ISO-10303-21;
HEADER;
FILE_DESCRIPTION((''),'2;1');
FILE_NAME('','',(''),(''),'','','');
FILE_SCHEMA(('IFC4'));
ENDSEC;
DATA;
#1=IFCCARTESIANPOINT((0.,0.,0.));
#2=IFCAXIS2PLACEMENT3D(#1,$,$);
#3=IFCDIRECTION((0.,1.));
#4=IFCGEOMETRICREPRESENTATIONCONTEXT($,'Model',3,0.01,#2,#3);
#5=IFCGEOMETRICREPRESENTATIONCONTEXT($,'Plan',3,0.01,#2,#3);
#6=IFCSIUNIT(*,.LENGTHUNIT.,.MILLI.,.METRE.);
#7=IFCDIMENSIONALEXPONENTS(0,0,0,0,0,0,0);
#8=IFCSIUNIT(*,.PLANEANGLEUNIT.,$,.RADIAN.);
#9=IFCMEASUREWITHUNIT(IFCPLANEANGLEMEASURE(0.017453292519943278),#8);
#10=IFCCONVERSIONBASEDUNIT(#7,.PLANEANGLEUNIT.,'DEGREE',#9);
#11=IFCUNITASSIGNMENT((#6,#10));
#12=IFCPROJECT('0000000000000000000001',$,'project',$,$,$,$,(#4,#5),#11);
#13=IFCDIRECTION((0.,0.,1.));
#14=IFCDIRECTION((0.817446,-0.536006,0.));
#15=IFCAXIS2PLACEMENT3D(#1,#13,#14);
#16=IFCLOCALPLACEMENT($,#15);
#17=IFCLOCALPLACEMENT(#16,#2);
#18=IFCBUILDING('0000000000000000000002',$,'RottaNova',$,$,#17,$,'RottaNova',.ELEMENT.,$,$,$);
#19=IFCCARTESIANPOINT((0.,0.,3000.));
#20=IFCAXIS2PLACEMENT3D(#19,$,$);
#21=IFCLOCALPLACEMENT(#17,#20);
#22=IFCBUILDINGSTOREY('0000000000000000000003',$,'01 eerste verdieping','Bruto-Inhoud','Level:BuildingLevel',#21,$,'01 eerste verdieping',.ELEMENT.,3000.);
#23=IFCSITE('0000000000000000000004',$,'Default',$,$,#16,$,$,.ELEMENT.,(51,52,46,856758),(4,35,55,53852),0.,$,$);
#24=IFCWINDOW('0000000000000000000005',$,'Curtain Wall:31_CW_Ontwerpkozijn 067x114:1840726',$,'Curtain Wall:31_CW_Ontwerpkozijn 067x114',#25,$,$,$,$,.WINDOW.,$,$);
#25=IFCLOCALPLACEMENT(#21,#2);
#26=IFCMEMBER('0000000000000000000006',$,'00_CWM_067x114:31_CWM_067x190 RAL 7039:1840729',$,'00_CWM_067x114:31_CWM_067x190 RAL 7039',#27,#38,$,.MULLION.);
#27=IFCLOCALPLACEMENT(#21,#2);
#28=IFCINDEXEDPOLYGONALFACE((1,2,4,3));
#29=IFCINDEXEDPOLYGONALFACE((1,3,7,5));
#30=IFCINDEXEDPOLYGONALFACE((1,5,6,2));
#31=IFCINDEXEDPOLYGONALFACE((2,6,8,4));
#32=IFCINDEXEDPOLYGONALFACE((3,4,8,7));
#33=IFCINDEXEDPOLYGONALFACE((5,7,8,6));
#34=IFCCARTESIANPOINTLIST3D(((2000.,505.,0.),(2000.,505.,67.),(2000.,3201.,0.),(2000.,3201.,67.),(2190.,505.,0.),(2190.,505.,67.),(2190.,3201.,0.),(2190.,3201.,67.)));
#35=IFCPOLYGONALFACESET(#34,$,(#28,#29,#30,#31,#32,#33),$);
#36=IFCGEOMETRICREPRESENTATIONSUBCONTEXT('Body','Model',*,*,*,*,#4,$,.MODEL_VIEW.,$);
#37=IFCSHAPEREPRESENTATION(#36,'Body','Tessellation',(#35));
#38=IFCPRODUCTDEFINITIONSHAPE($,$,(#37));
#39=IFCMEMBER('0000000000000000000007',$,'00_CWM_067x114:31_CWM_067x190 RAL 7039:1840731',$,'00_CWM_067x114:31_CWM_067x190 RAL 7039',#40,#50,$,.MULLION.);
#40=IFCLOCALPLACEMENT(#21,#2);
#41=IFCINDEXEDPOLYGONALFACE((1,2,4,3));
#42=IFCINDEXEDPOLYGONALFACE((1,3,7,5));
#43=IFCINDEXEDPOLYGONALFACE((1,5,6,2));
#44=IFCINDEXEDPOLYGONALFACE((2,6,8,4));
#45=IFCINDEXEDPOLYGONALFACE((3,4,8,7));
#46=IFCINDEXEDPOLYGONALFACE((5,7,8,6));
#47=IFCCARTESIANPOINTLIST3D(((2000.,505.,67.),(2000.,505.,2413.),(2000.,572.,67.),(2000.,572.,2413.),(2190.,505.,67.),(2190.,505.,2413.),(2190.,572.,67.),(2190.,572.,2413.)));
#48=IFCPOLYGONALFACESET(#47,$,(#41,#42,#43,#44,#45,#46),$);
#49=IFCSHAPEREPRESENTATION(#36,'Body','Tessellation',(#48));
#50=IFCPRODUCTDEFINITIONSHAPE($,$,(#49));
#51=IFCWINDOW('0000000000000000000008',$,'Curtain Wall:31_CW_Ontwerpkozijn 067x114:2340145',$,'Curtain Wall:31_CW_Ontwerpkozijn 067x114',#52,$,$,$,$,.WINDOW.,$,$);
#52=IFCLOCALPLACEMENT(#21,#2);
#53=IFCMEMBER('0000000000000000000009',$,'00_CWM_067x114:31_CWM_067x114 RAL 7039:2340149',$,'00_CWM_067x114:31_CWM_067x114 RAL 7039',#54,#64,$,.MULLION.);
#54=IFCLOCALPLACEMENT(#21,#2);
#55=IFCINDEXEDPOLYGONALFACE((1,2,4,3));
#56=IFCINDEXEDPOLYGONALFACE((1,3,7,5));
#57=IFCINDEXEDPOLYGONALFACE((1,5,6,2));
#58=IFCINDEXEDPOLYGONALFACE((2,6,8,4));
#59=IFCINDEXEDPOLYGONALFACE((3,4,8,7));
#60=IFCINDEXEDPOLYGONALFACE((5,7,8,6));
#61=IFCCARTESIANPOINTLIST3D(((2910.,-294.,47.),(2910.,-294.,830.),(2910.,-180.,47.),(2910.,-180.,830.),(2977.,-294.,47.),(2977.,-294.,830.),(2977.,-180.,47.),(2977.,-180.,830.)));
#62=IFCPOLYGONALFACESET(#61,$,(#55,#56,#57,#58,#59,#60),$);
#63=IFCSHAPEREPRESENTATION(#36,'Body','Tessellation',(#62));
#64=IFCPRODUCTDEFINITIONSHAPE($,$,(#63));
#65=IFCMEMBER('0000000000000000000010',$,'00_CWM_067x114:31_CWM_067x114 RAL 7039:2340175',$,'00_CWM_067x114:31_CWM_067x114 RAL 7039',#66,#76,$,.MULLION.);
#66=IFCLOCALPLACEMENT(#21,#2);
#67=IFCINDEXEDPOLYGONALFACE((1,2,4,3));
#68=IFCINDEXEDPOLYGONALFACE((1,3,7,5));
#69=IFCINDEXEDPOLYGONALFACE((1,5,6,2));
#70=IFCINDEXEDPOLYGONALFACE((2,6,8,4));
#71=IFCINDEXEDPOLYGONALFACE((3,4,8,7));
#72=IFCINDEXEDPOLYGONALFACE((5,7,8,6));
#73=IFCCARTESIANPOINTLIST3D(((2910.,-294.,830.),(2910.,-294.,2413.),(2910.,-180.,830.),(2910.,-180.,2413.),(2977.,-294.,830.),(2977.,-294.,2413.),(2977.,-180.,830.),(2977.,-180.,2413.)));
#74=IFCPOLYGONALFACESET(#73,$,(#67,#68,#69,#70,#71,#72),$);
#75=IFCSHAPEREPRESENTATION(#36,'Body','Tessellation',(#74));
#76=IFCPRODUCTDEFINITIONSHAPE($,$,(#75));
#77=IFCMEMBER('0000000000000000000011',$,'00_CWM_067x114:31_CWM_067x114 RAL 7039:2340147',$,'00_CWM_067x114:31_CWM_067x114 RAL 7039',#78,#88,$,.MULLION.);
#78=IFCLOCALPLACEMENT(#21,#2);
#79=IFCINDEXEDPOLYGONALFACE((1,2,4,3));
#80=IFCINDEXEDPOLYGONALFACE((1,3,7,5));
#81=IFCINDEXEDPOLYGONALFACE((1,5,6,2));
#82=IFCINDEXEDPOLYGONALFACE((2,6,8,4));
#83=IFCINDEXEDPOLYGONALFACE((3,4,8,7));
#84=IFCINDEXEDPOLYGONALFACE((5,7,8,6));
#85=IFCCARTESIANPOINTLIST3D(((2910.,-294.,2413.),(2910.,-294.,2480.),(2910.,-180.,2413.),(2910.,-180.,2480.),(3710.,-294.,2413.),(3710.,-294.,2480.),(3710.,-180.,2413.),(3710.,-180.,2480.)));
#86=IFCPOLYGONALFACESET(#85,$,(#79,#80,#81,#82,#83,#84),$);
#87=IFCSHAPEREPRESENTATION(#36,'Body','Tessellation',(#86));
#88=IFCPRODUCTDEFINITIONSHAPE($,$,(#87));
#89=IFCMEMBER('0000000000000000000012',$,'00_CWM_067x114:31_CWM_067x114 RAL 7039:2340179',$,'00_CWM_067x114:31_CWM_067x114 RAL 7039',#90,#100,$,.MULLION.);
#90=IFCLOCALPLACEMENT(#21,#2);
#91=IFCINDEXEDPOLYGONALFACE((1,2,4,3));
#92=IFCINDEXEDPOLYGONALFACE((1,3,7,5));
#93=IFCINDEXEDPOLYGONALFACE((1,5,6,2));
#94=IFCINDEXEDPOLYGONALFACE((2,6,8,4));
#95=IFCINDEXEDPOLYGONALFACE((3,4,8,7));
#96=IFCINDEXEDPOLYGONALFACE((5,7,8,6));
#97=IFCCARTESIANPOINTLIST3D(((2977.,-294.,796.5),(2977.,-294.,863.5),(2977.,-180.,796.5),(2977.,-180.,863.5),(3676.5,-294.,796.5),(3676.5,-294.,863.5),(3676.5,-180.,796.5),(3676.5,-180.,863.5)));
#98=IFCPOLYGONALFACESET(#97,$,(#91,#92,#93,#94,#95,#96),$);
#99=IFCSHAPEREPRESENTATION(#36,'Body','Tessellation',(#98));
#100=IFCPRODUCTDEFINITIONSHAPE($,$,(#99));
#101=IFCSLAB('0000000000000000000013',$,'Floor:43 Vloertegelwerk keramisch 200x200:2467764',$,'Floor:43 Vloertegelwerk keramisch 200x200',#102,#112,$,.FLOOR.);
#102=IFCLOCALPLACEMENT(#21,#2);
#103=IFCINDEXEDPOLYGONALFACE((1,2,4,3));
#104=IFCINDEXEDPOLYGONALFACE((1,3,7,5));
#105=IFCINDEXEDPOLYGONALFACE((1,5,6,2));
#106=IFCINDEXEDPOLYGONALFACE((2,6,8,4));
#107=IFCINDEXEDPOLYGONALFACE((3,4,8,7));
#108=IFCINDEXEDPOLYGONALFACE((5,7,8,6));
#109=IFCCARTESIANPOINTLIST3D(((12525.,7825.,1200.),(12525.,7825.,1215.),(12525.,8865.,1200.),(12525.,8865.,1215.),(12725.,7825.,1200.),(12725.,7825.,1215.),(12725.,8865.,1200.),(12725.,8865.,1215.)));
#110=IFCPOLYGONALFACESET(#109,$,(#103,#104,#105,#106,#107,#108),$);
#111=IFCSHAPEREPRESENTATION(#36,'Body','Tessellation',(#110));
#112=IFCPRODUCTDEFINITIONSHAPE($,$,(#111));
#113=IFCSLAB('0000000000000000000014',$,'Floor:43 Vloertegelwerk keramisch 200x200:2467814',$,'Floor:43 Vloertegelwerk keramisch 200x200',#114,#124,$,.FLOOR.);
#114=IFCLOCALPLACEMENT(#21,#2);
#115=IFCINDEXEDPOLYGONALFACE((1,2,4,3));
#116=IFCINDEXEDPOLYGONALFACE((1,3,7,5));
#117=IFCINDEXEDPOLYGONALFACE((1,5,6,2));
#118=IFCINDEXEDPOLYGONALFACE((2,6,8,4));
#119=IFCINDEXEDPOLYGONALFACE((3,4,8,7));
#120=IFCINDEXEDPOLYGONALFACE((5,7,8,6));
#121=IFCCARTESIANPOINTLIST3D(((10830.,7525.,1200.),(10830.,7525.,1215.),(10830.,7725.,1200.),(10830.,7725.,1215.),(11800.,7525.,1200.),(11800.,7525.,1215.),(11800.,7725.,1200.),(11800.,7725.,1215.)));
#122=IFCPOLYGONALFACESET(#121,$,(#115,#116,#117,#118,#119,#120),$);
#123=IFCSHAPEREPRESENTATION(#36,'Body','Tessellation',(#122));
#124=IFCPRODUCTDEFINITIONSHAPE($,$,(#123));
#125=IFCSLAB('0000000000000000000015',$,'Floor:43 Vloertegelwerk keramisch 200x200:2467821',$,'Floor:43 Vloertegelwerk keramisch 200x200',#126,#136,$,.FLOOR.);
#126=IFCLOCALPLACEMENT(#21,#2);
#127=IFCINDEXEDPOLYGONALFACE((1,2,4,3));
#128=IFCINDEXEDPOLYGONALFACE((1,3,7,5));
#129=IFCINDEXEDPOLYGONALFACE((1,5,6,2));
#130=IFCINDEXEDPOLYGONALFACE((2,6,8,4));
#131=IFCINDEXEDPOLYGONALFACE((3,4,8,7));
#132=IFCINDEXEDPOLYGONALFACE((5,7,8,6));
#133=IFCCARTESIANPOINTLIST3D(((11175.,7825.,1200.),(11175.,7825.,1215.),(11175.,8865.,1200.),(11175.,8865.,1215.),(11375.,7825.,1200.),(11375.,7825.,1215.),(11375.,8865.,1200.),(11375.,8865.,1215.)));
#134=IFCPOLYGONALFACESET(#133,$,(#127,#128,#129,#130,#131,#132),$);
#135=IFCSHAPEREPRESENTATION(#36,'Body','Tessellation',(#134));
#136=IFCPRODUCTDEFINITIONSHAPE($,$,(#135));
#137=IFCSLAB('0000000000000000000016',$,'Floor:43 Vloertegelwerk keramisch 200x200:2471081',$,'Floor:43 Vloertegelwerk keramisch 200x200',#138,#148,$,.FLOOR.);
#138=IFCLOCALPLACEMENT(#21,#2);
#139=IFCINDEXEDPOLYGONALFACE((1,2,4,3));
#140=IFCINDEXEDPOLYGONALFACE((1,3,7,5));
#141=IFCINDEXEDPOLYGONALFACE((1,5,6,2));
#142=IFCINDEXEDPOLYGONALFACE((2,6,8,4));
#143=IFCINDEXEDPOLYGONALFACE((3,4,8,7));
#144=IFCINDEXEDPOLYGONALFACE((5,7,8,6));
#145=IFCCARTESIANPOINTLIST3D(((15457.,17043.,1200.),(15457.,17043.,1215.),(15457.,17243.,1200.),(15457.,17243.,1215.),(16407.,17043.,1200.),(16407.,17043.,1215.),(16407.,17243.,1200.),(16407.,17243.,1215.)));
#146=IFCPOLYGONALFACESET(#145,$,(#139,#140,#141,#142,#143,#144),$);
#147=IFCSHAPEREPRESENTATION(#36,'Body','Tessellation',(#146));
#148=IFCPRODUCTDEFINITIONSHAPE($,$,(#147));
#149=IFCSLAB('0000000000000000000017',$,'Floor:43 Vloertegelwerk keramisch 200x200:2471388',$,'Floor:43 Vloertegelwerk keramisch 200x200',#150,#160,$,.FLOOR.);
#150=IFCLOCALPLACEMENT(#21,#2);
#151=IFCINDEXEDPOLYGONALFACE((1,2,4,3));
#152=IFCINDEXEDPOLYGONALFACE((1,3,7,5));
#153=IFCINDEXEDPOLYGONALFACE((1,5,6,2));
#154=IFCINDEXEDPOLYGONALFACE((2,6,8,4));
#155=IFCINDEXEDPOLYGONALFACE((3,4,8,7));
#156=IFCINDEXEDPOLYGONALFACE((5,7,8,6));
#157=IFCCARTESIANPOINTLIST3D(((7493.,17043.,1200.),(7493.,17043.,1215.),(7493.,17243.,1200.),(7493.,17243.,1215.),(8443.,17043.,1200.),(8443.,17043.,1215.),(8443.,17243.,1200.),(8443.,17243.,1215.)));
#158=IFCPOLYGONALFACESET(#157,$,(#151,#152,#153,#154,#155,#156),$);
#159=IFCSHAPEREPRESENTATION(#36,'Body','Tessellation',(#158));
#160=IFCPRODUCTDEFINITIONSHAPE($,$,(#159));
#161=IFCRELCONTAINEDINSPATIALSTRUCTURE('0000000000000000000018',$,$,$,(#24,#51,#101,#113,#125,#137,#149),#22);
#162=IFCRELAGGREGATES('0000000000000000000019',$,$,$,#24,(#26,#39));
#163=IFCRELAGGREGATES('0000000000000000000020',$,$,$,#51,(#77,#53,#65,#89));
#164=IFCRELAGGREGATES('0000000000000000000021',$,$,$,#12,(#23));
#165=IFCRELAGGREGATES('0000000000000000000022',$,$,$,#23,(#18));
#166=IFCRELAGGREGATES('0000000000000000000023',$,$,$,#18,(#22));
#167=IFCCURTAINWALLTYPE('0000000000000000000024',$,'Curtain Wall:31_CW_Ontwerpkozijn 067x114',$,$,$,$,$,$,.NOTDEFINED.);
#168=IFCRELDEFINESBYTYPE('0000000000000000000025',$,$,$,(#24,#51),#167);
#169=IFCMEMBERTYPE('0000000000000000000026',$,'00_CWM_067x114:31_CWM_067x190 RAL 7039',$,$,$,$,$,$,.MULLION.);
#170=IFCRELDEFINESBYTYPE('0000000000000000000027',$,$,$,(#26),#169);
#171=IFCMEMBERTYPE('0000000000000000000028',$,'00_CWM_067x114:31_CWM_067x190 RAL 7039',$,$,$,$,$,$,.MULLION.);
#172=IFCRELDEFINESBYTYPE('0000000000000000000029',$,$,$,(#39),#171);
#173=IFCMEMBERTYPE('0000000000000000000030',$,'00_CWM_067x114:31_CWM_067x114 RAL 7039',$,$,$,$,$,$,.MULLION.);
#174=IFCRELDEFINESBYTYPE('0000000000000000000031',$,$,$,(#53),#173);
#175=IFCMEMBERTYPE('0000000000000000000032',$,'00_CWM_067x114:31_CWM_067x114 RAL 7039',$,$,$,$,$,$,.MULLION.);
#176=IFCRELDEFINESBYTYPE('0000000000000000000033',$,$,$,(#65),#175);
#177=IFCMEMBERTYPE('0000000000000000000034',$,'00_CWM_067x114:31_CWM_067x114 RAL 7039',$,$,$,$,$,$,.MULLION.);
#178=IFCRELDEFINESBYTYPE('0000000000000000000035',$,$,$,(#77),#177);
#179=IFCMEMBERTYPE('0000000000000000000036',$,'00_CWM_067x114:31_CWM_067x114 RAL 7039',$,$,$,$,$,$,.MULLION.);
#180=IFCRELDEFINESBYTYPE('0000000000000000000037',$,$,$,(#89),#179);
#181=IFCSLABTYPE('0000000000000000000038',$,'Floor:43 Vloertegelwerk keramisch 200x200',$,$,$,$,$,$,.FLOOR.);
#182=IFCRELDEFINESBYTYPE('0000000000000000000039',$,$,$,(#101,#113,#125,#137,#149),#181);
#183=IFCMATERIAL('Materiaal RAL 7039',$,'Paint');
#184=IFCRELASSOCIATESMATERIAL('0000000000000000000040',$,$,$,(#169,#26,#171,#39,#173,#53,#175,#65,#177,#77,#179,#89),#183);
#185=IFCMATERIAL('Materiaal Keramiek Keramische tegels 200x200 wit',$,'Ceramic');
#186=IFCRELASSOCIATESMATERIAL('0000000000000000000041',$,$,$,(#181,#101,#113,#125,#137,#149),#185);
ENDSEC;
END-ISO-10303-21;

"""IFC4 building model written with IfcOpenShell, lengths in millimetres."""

from ifc_helpers import new_model, entity, si_unit, converted_unit, direction, frame, origin, place, context, subcontext, project, spatial, indexed_curve, outline, extrude, source, transform, mapped, material, type_object, type_shapes, element, aggregate, save


model = new_model("IFC4")

# Units and contexts
model_context = context("Model", 3, precision=0.01, world=origin(), true_north=direction((0.0, 1.0)))
plan_context = context("Plan", 3, precision=0.01, world=origin(), true_north=direction((0.0, 1.0)))
body_context = subcontext(model_context, "Body", "Model", "MODEL_VIEW")
ifc_project = project(units=[si_unit("LENGTHUNIT", "METRE", prefix="MILLI"), converted_unit("PLANEANGLEUNIT", "DEGREE", entity("IfcPlaneAngleMeasure", 0.017453292519943278), si_unit("PLANEANGLEUNIT", "RADIAN"), dimensions=[0, 0, 0, 0, 0, 0, 0])], contexts=[model_context, plan_context])

# Site, building, storey
site_placement = place(None, frame((0.0, 0.0, 0.0), z_axis=(0.0, 0.0, 1.0), x_axis=(0.817446, -0.536006, 0.0)))
site = spatial("IfcSite", under=ifc_project, at=site_placement, Name="Default", CompositionType="ELEMENT", RefLatitude=(51, 52, 46, 856758), RefLongitude=(4, 35, 55, 53852), RefElevation=0.0)
building_placement = place(site_placement, origin())
building = spatial("IfcBuilding", under=site, at=building_placement, Name="RottaNova", LongName="RottaNova", CompositionType="ELEMENT")
storey_placement = place(building_placement, frame((0.0, 0.0, 3000.0)))
storey = spatial("IfcBuildingStorey", under=building, at=storey_placement, Name="01 eerste verdieping", Description="Bruto-Inhoud", ObjectType="Level:BuildingLevel", LongName="01 eerste verdieping", CompositionType="ELEMENT", Elevation=3000.0)

# Windows, members
curtain_wall_type = type_object("IfcCurtainWallType", Name="Curtain Wall:31_CW_Ontwerpkozijn 067x114", PredefinedType="NOTDEFINED")
window_1_placement = place(storey_placement, frame((0.0, 0.0, -3000.0)))
window_1 = element("IfcWindow", 1, at=window_1_placement, inside=storey, type_object=curtain_wall_type, Name="Curtain Wall:31_CW_Ontwerpkozijn 067x114:1840726", ObjectType="Curtain Wall:31_CW_Ontwerpkozijn 067x114", PredefinedType="WINDOW")
ifc_material_1 = material(Name="Materiaal RAL 7039", Category="Paint")
member_type_1 = type_object("IfcMemberType", Name="00_CWM_067x114:31_CWM_067x190 RAL 7039", PredefinedType="MULLION", material=ifc_material_1)
shared_shape_1 = source(origin(), body_context, "Body", "SweptSolid", [
    extrude(outline(indexed_curve([(-33.5, -95.0), (33.5, -95.0), (33.5, 95.0), (-33.5, 95.0), (-33.5, -95.0)], self_intersect=False)), frame((-33.5, -95.0, -2696.0), z_axis=(0.0, 0.0, 1.0), x_axis=(-1.0, 0.0, 0.0)), (0.0, 0.0, 1.0), 2696.0),
])
type_shapes(member_type_1, [shared_shape_1])
member_1_placement = place(window_1_placement, frame((2190.0, 505.0, 3000.0), z_axis=(0.0, -1.0, 0.0), x_axis=(0.0, 0.0, -1.0)))
member_1 = element("IfcMember", 2, at=member_1_placement, type_object=member_type_1, material=ifc_material_1, Name="00_CWM_067x114:31_CWM_067x190 RAL 7039:1840729", ObjectType="00_CWM_067x114:31_CWM_067x190 RAL 7039", PredefinedType="MULLION", context=body_context, shape_type="MappedRepresentation", body=[
    mapped(shared_shape_1, transform((0.0, 0.0, 0.0), scale=1.0)),
])
member_type_2 = type_object("IfcMemberType", Name="00_CWM_067x114:31_CWM_067x190 RAL 7039", PredefinedType="MULLION", material=ifc_material_1)
shared_shape_2 = source(origin(), body_context, "Body", "SweptSolid", [
    extrude(outline(indexed_curve([(-33.5, -95.0), (33.5, -95.0), (33.5, 95.0), (-33.5, 95.0), (-33.5, -95.0)], self_intersect=False)), frame((-33.5, -95.0, -2346.0), z_axis=(0.0, 0.0, 1.0), x_axis=(-1.0, 0.0, 0.0)), (0.0, 0.0, 1.0), 2346.0),
])
type_shapes(member_type_2, [shared_shape_2])
member_2_placement = place(window_1_placement, frame((2190.0, 505.0, 5413.0), z_axis=(0.0, 0.0, 1.0), x_axis=(0.0, -1.0, 0.0)))
member_2 = element("IfcMember", 3, at=member_2_placement, type_object=member_type_2, material=ifc_material_1, Name="00_CWM_067x114:31_CWM_067x190 RAL 7039:1840731", ObjectType="00_CWM_067x114:31_CWM_067x190 RAL 7039", PredefinedType="MULLION", context=body_context, shape_type="MappedRepresentation", body=[
    mapped(shared_shape_2, transform((0.0, 0.0, 0.0), scale=1.0)),
])
aggregate(window_1, [member_1, member_2])
window_2_placement = place(storey_placement, frame((0.0, 0.0, -3000.0)))
window_2 = element("IfcWindow", 4, at=window_2_placement, inside=storey, type_object=curtain_wall_type, Name="Curtain Wall:31_CW_Ontwerpkozijn 067x114:2340145", ObjectType="Curtain Wall:31_CW_Ontwerpkozijn 067x114", PredefinedType="WINDOW")
member_type_3 = type_object("IfcMemberType", Name="00_CWM_067x114:31_CWM_067x114 RAL 7039", PredefinedType="MULLION", material=ifc_material_1)
shared_shape_3 = source(origin(), body_context, "Body", "SweptSolid", [
    extrude(outline(indexed_curve([(-33.5, -57.0), (33.5, -57.0), (33.5, 57.0), (-33.5, 57.0), (-33.5, -57.0)], self_intersect=False)), frame((-33.5, -57.0, -783.0), z_axis=(0.0, 0.0, 1.0), x_axis=(-1.0, 0.0, 0.0)), (0.0, 0.0, 1.0), 783.0),
])
type_shapes(member_type_3, [shared_shape_3])
member_3_placement = place(window_2_placement, frame((2910.0, -180.0, 3047.0), z_axis=(0.0, 0.0, -1.0), x_axis=(-1.0, 0.0, 0.0)))
member_3 = element("IfcMember", 5, at=member_3_placement, type_object=member_type_3, material=ifc_material_1, Name="00_CWM_067x114:31_CWM_067x114 RAL 7039:2340149", ObjectType="00_CWM_067x114:31_CWM_067x114 RAL 7039", PredefinedType="MULLION", context=body_context, shape_type="MappedRepresentation", body=[
    mapped(shared_shape_3, transform((0.0, 0.0, 0.0), scale=1.0)),
])
member_type_4 = type_object("IfcMemberType", Name="00_CWM_067x114:31_CWM_067x114 RAL 7039", PredefinedType="MULLION", material=ifc_material_1)
shared_shape_4 = source(origin(), body_context, "Body", "SweptSolid", [
    extrude(outline(indexed_curve([(-33.5, -57.0), (33.5, -57.0), (33.5, 57.0), (-33.5, 57.0), (-33.5, -57.0)], self_intersect=False)), frame((-33.5, -57.0, -1583.0), z_axis=(0.0, 0.0, 1.0), x_axis=(-1.0, 0.0, 0.0)), (0.0, 0.0, 1.0), 1583.0),
])
type_shapes(member_type_4, [shared_shape_4])
member_4_placement = place(window_2_placement, frame((2910.0, -180.0, 3830.0), z_axis=(0.0, 0.0, -1.0), x_axis=(-1.0, 0.0, 0.0)))
member_4 = element("IfcMember", 6, at=member_4_placement, type_object=member_type_4, material=ifc_material_1, Name="00_CWM_067x114:31_CWM_067x114 RAL 7039:2340175", ObjectType="00_CWM_067x114:31_CWM_067x114 RAL 7039", PredefinedType="MULLION", context=body_context, shape_type="MappedRepresentation", body=[
    mapped(shared_shape_4, transform((0.0, 0.0, 0.0), scale=1.0)),
])
member_type_5 = type_object("IfcMemberType", Name="00_CWM_067x114:31_CWM_067x114 RAL 7039", PredefinedType="MULLION", material=ifc_material_1)
shared_shape_5 = source(origin(), body_context, "Body", "SweptSolid", [
    extrude(outline(indexed_curve([(-33.5, -57.0), (33.5, -57.0), (33.5, 57.0), (-33.5, 57.0), (-33.5, -57.0)], self_intersect=False)), frame((-33.5, -57.0, -800.0), z_axis=(0.0, 0.0, 1.0), x_axis=(-1.0, 0.0, 0.0)), (0.0, 0.0, 1.0), 800.0),
])
type_shapes(member_type_5, [shared_shape_5])
member_5_placement = place(window_2_placement, frame((2910.0, -180.0, 5480.0), z_axis=(-1.0, 0.0, 0.0), x_axis=(0.0, 0.0, 1.0)))
member_5 = element("IfcMember", 7, at=member_5_placement, type_object=member_type_5, material=ifc_material_1, Name="00_CWM_067x114:31_CWM_067x114 RAL 7039:2340147", ObjectType="00_CWM_067x114:31_CWM_067x114 RAL 7039", PredefinedType="MULLION", context=body_context, shape_type="MappedRepresentation", body=[
    mapped(shared_shape_5, transform((0.0, 0.0, 0.0), scale=1.0)),
])
member_type_6 = type_object("IfcMemberType", Name="00_CWM_067x114:31_CWM_067x114 RAL 7039", PredefinedType="MULLION", material=ifc_material_1)
shared_shape_6 = source(origin(), body_context, "Body", "SweptSolid", [
    extrude(outline(indexed_curve([(-33.5, -57.0), (33.5, -57.0), (33.5, 57.0), (-33.5, 57.0), (-33.5, -57.0)], self_intersect=False)), frame((0.0, -57.0, -699.5), z_axis=(0.0, 0.0, 1.0), x_axis=(-1.0, 0.0, 0.0)), (0.0, 0.0, 1.0), 699.5),
])
type_shapes(member_type_6, [shared_shape_6])
member_6_placement = place(window_2_placement, frame((2977.0, -180.0, 3830.0), z_axis=(-1.0, 0.0, 0.0), x_axis=(0.0, 0.0, 1.0)))
member_6 = element("IfcMember", 8, at=member_6_placement, type_object=member_type_6, material=ifc_material_1, Name="00_CWM_067x114:31_CWM_067x114 RAL 7039:2340179", ObjectType="00_CWM_067x114:31_CWM_067x114 RAL 7039", PredefinedType="MULLION", context=body_context, shape_type="MappedRepresentation", body=[
    mapped(shared_shape_6, transform((0.0, 0.0, 0.0), scale=1.0)),
])
aggregate(window_2, [member_5, member_3, member_4, member_6])

# Slabs
ifc_material_2 = material(Name="Materiaal Keramiek Keramische tegels 200x200 wit", Category="Ceramic")
slab_type = type_object("IfcSlabType", Name="Floor:43 Vloertegelwerk keramisch 200x200", PredefinedType="FLOOR", material=ifc_material_2)
slab_1_placement = place(storey_placement, origin())
element("IfcSlab", 9, at=slab_1_placement, inside=storey, type_object=slab_type, material=ifc_material_2, Name="Floor:43 Vloertegelwerk keramisch 200x200:2467764", ObjectType="Floor:43 Vloertegelwerk keramisch 200x200", PredefinedType="FLOOR", context=body_context, shape_type="SweptSolid", body=[
    extrude(outline(indexed_curve([(-520.0, -100.0), (520.0, -100.0), (520.0, 100.0), (-520.0, 100.0), (-520.0, -100.0)], self_intersect=False)), frame((12625.0, 8345.0, 1215.0), z_axis=(0.0, 0.0, -1.0), x_axis=(0.0, 1.0, 0.0)), (0.0, 0.0, 1.0), 15.0),
])
slab_2_placement = place(storey_placement, origin())
element("IfcSlab", 10, at=slab_2_placement, inside=storey, type_object=slab_type, material=ifc_material_2, Name="Floor:43 Vloertegelwerk keramisch 200x200:2467814", ObjectType="Floor:43 Vloertegelwerk keramisch 200x200", PredefinedType="FLOOR", context=body_context, shape_type="SweptSolid", body=[
    extrude(outline(indexed_curve([(-100.0, -485.0), (100.0, -485.0), (100.0, 485.0), (-100.0, 485.0), (-100.0, -485.0)], self_intersect=False)), frame((11315.0, 7625.0, 1215.0), z_axis=(0.0, 0.0, -1.0), x_axis=(0.0, 1.0, 0.0)), (0.0, 0.0, 1.0), 15.0),
])
slab_3_placement = place(storey_placement, origin())
element("IfcSlab", 11, at=slab_3_placement, inside=storey, type_object=slab_type, material=ifc_material_2, Name="Floor:43 Vloertegelwerk keramisch 200x200:2467821", ObjectType="Floor:43 Vloertegelwerk keramisch 200x200", PredefinedType="FLOOR", context=body_context, shape_type="SweptSolid", body=[
    extrude(outline(indexed_curve([(-520.0, -100.0), (520.0, -100.0), (520.0, 100.0), (-520.0, 100.0), (-520.0, -100.0)], self_intersect=False)), frame((11275.0, 8345.0, 1215.0), z_axis=(0.0, 0.0, -1.0), x_axis=(0.0, 1.0, 0.0)), (0.0, 0.0, 1.0), 15.0),
])
slab_4_placement = place(storey_placement, origin())
element("IfcSlab", 12, at=slab_4_placement, inside=storey, type_object=slab_type, material=ifc_material_2, Name="Floor:43 Vloertegelwerk keramisch 200x200:2471081", ObjectType="Floor:43 Vloertegelwerk keramisch 200x200", PredefinedType="FLOOR", context=body_context, shape_type="SweptSolid", body=[
    extrude(outline(indexed_curve([(-100.0, -475.0), (100.0, -475.0), (100.0, 475.0), (-100.0, 475.0), (-100.0, -475.0)], self_intersect=False)), frame((15932.0, 17143.0, 1215.0), z_axis=(0.0, 0.0, -1.0), x_axis=(0.0, 1.0, 0.0)), (0.0, 0.0, 1.0), 15.0),
])
slab_5_placement = place(storey_placement, origin())
element("IfcSlab", 13, at=slab_5_placement, inside=storey, type_object=slab_type, material=ifc_material_2, Name="Floor:43 Vloertegelwerk keramisch 200x200:2471388", ObjectType="Floor:43 Vloertegelwerk keramisch 200x200", PredefinedType="FLOOR", context=body_context, shape_type="SweptSolid", body=[
    extrude(outline(indexed_curve([(-100.0, -475.0), (100.0, -475.0), (100.0, 475.0), (-100.0, 475.0), (-100.0, -475.0)], self_intersect=False)), frame((7968.0, 17143.0, 1215.0), z_axis=(0.0, 0.0, -1.0), x_axis=(0.0, 1.0, 0.0)), (0.0, 0.0, 1.0), 15.0),
])

save(model, "model.ifc")
